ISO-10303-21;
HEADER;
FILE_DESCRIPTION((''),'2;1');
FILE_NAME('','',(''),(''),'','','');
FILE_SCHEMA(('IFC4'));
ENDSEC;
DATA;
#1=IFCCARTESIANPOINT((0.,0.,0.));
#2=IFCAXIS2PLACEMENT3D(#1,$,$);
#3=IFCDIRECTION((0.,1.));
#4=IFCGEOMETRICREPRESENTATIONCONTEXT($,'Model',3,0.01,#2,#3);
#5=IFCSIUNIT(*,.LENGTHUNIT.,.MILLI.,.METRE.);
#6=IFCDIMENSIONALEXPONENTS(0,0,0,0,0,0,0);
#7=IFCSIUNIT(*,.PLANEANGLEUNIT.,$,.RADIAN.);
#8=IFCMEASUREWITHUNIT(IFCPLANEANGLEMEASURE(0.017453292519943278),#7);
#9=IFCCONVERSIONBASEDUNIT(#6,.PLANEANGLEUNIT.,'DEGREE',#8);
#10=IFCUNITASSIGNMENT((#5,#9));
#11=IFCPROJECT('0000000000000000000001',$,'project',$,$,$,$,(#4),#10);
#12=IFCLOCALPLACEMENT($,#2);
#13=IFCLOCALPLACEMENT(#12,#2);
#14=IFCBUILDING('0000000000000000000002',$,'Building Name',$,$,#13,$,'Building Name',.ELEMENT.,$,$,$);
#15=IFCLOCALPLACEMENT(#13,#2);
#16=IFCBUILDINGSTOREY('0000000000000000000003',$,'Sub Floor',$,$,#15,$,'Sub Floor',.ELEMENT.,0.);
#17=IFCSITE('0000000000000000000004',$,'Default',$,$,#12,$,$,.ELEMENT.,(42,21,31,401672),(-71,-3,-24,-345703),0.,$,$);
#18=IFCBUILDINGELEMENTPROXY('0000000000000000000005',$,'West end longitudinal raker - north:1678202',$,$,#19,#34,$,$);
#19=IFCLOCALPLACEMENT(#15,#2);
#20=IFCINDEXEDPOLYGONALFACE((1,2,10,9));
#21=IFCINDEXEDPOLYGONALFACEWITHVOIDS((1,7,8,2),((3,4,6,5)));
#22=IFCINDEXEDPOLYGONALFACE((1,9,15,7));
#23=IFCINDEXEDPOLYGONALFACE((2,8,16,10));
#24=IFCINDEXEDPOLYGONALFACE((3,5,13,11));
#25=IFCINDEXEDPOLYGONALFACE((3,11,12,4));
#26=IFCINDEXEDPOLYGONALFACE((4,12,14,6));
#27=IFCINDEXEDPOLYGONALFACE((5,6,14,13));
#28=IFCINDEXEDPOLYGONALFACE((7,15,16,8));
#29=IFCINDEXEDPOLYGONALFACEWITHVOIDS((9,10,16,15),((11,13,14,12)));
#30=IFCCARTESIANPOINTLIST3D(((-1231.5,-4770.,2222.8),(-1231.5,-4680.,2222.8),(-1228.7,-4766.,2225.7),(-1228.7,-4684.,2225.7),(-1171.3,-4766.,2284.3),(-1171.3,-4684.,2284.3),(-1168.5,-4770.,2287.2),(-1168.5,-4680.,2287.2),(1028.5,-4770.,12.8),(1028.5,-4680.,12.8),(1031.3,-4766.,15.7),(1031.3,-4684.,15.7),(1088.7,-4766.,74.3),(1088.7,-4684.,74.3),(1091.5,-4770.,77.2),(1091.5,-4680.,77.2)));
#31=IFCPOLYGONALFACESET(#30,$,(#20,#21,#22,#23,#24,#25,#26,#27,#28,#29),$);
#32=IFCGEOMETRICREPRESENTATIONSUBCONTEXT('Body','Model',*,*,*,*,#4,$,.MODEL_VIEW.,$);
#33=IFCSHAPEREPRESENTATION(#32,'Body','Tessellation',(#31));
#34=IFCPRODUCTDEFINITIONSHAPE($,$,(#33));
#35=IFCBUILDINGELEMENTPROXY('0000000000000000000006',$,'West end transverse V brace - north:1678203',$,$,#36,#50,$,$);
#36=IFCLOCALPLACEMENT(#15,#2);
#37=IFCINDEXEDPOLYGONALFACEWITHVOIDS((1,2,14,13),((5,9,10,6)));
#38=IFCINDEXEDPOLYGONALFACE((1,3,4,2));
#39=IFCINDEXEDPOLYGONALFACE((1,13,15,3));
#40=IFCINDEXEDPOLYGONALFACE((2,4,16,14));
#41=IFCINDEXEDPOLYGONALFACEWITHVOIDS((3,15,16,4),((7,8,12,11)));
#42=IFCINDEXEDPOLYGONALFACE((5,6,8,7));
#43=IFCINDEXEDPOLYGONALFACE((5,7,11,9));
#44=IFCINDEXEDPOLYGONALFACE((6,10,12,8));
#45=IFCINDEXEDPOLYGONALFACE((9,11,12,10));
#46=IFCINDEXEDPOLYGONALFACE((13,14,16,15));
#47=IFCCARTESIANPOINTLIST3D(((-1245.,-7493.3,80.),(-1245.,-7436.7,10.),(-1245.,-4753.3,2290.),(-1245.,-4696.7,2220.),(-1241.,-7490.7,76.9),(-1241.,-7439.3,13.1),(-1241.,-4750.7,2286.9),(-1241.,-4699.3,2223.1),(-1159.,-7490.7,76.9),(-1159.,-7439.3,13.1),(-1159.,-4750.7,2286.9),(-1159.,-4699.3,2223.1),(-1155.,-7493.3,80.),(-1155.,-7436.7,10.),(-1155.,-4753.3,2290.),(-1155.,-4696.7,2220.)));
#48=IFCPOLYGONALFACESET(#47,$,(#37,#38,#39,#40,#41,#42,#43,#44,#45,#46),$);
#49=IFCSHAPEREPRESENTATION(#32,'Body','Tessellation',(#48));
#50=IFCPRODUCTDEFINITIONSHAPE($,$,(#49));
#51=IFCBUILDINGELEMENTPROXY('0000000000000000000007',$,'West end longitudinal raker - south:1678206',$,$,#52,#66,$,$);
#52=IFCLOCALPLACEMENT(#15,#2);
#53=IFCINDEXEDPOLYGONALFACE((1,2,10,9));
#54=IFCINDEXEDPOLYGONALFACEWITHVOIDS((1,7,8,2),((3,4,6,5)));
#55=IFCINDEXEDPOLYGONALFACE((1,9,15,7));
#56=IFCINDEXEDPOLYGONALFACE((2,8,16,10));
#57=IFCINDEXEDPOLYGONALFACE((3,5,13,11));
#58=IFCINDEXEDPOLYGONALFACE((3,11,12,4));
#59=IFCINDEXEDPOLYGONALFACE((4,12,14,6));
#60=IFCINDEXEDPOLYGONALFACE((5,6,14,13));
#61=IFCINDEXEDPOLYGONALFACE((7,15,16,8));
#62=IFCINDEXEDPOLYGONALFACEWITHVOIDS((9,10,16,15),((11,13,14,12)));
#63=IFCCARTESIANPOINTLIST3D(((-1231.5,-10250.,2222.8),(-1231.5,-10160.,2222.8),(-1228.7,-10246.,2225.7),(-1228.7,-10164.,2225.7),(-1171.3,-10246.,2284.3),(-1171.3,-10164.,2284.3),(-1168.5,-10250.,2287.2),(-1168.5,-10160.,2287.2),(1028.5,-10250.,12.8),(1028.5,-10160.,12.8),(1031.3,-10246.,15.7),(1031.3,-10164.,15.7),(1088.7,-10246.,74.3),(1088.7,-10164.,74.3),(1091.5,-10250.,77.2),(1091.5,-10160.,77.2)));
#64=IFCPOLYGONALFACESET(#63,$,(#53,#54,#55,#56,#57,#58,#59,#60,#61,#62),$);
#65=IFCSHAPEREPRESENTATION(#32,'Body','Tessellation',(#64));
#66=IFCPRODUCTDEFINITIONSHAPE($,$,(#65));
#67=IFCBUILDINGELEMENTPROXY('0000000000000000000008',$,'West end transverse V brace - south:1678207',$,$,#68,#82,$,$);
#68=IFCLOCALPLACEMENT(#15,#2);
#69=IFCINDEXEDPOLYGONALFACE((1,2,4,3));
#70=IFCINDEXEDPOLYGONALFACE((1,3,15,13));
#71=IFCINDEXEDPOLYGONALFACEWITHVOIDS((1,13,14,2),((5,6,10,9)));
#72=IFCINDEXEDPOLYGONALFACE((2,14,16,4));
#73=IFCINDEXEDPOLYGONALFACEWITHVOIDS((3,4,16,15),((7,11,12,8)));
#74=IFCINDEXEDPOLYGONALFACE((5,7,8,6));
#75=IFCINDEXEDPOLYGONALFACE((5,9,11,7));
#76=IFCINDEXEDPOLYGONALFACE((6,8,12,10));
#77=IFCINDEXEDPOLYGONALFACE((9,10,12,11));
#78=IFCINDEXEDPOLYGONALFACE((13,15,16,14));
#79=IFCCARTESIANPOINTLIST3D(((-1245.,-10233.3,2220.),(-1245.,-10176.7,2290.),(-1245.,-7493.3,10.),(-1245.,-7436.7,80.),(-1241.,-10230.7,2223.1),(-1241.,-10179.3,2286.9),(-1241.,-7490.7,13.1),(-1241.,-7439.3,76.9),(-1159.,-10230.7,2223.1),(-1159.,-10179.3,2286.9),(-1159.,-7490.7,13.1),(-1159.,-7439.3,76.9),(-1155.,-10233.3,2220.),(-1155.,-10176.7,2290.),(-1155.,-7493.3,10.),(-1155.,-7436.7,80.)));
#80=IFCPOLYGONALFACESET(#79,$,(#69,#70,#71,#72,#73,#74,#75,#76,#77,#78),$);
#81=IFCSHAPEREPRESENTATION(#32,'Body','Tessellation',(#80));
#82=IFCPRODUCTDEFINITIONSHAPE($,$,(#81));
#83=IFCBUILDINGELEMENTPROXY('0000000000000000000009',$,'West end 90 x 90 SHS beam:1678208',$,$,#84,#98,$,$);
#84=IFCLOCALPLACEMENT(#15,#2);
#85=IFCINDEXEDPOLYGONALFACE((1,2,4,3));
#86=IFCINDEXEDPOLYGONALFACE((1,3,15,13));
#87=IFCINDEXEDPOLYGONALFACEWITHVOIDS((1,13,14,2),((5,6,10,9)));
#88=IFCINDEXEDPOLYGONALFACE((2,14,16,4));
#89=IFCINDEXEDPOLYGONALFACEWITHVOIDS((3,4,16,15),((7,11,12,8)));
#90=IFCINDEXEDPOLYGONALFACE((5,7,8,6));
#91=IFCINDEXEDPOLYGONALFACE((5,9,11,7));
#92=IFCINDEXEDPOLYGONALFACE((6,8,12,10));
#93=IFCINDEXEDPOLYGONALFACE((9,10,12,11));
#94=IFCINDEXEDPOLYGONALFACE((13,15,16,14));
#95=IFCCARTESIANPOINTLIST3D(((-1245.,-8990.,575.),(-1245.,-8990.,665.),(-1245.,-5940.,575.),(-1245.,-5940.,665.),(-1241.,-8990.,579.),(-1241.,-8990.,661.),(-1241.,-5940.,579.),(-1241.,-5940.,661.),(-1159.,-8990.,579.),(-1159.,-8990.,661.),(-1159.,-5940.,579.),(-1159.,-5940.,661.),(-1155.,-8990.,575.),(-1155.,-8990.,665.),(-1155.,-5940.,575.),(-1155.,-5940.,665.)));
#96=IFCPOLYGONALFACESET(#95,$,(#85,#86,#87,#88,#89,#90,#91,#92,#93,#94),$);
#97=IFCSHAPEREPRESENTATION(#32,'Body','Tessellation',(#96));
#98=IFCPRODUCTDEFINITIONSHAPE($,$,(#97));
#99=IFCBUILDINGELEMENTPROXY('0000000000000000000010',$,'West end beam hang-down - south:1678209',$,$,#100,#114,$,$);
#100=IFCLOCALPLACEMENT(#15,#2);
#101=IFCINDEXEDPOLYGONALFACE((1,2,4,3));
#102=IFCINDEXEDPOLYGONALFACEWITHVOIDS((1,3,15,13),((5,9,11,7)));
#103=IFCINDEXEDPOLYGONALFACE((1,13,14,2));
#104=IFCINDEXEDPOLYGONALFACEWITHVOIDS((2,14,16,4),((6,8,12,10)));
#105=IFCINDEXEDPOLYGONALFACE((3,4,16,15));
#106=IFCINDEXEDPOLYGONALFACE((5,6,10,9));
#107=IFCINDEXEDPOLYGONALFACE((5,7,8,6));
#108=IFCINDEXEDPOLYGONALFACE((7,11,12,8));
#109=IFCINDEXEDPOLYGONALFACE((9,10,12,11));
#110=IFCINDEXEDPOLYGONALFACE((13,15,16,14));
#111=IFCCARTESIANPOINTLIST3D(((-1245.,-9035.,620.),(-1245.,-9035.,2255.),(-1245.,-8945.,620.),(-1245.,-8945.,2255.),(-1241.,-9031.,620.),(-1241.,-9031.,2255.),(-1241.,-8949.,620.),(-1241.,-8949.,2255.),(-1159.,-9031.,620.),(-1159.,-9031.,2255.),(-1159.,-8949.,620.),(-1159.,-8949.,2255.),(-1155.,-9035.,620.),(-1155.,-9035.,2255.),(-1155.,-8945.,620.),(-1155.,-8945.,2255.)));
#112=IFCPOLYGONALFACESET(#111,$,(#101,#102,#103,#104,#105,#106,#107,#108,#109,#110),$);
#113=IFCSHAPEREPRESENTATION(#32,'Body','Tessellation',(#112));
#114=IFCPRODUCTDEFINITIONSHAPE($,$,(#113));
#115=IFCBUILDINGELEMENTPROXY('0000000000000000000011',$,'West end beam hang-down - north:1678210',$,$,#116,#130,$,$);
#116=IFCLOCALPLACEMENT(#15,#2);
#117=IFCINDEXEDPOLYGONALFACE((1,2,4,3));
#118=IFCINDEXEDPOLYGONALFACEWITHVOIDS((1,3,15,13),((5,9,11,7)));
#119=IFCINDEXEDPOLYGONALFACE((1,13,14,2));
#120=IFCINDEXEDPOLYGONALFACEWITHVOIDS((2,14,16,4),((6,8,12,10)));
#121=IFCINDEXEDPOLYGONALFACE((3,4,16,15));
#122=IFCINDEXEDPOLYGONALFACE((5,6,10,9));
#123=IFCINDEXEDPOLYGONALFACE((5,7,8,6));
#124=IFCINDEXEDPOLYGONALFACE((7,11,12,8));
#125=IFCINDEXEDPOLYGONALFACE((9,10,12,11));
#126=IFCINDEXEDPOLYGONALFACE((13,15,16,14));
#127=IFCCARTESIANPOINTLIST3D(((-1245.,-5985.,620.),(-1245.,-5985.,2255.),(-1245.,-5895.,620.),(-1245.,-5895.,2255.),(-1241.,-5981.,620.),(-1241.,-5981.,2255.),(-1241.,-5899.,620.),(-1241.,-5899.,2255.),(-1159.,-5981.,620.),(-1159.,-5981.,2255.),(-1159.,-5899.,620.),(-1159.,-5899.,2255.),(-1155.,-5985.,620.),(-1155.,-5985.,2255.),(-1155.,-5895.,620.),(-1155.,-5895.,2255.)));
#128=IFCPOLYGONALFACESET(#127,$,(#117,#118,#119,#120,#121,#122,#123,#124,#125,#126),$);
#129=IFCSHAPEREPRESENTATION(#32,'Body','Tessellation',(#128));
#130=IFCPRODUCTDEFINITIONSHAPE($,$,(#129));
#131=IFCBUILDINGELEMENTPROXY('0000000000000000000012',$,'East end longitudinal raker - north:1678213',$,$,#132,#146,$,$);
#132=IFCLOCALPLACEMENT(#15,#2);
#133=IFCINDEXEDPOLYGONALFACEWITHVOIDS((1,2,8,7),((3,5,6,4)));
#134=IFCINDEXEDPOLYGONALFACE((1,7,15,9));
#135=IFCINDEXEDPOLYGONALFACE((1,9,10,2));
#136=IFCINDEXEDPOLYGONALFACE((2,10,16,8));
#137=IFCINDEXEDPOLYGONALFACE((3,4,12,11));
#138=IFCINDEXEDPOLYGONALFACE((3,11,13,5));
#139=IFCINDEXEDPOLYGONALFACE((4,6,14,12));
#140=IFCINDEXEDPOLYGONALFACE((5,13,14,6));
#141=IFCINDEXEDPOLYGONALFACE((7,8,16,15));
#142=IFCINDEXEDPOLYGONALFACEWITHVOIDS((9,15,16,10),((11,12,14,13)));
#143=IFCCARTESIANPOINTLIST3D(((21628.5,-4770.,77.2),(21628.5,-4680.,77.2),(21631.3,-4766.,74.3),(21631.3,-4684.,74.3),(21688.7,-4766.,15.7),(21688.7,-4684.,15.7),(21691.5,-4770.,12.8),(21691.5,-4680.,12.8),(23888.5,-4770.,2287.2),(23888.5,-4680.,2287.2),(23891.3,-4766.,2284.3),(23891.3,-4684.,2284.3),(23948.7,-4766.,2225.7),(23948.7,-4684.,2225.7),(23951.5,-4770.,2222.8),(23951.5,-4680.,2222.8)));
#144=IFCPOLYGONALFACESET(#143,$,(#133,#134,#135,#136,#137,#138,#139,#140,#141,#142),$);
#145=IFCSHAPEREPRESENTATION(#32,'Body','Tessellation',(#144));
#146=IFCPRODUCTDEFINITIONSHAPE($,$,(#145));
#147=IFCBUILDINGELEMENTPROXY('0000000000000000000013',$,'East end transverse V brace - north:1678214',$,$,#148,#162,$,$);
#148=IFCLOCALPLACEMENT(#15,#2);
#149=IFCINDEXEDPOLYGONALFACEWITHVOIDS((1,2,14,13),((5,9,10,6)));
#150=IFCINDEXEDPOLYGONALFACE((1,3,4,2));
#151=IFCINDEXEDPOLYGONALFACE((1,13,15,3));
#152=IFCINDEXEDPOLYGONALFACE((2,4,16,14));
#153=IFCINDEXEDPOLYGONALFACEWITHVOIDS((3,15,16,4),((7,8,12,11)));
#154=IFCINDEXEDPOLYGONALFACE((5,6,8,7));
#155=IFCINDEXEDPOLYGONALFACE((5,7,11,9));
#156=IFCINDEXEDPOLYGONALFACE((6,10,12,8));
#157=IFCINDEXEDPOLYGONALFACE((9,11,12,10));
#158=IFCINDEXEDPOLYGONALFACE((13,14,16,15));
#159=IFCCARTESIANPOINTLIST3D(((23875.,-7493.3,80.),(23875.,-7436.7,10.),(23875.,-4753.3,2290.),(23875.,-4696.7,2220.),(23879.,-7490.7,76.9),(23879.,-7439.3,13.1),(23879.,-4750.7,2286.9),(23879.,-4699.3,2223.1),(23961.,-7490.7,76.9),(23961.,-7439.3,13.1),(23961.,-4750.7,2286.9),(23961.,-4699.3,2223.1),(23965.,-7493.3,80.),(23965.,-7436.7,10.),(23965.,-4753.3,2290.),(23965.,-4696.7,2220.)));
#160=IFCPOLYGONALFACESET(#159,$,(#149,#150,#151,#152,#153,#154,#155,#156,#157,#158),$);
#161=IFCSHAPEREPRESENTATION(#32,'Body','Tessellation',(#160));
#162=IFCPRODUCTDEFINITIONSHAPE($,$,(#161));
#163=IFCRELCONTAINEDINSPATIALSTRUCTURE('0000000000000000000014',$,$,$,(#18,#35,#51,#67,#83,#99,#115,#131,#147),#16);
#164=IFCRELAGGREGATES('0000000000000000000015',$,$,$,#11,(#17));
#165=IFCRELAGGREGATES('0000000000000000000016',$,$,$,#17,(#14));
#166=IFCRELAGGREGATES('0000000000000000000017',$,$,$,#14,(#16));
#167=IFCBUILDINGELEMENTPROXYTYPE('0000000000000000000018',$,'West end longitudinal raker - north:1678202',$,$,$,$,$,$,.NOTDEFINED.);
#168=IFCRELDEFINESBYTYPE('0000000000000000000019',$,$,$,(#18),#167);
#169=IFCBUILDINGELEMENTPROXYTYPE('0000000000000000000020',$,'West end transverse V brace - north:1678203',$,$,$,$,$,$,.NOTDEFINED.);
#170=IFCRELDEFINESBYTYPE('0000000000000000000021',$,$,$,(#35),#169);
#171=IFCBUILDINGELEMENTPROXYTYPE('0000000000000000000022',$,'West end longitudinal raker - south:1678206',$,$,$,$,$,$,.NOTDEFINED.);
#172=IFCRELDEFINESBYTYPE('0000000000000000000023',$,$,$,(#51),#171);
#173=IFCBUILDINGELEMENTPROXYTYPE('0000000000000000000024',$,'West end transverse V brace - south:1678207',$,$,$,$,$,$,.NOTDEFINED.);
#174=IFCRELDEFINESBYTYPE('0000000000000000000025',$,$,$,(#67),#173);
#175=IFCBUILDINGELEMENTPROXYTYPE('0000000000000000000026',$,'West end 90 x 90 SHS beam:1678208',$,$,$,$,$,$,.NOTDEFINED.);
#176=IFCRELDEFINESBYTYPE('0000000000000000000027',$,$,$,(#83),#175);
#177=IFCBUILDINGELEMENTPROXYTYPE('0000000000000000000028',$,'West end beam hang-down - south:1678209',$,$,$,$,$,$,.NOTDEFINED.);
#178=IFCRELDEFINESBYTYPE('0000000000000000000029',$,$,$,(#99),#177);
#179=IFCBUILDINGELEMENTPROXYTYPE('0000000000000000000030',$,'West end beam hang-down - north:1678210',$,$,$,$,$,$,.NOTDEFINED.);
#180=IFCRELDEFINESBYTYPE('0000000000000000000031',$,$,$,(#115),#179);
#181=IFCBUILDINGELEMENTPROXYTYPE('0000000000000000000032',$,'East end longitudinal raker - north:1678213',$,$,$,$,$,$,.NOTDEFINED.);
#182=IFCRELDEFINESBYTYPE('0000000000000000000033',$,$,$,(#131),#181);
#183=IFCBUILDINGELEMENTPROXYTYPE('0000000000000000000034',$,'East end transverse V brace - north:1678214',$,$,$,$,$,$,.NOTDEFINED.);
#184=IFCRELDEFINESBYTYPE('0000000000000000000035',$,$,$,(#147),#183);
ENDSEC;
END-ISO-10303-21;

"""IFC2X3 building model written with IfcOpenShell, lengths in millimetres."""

from ifc_helpers import new_model, entity, si_unit, converted_unit, direction, frame, origin, place, context, subcontext, project, spatial, polyline, outline, extrude, type_object, element, save


model = new_model("IFC2X3")

# Units and contexts
model_context = context("Model", 3, precision=0.01, world=origin(), true_north=direction((0.0, 1.0)))
body_context = subcontext(model_context, "Body", "Model", "MODEL_VIEW")
ifc_project = project(units=[si_unit("LENGTHUNIT", "METRE", prefix="MILLI"), converted_unit("PLANEANGLEUNIT", "DEGREE", entity("IfcPlaneAngleMeasure", 0.017453292519943278), si_unit("PLANEANGLEUNIT", "RADIAN"), dimensions=[0, 0, 0, 0, 0, 0, 0])], contexts=[model_context])

# Site, building, storey
site_placement = place(None, origin())
site = spatial("IfcSite", under=ifc_project, at=site_placement, Name="Default", CompositionType="ELEMENT", RefLatitude=(42, 21, 31, 401672), RefLongitude=(-71, -3, -24, -345703), RefElevation=0.0)
building_placement = place(site_placement, origin())
building = spatial("IfcBuilding", under=site, at=building_placement, Name="Building Name", LongName="Building Name", CompositionType="ELEMENT")
storey_placement = place(building_placement, origin())
storey = spatial("IfcBuildingStorey", under=building, at=storey_placement, Name="Sub Floor", LongName="Sub Floor", CompositionType="ELEMENT", Elevation=0.0)

# Building element proxies
building_element_proxy_type_1 = type_object("IfcBuildingElementProxyType", Name="West end longitudinal raker - north:1678202", PredefinedType="NOTDEFINED")
proxy_1_placement = place(storey_placement, origin())
element("IfcBuildingElementProxy", 1, at=proxy_1_placement, inside=storey, type_object=building_element_proxy_type_1, Name="West end longitudinal raker - north:1678202", context=body_context, shape_type="SweptSolid", body=[
    extrude(outline(polyline([(-45.0, -45.0), (45.0, -45.0), (45.0, 45.0), (-45.0, 45.0), (-45.0, -45.0)]), holes=[polyline([(-41.0, -41.0), (-41.0, 41.0), (41.0, 41.0), (41.0, -41.0), (-41.0, -41.0)])]), frame((-1200.0, -4725.0, 2255.0), z_axis=(0.714972, 0.0, -0.699154), x_axis=(-0.699154, 0.0, -0.714972)), (0.0, 0.0, 1.0), 3161.0),
])
building_element_proxy_type_2 = type_object("IfcBuildingElementProxyType", Name="West end transverse V brace - north:1678203", PredefinedType="NOTDEFINED")
proxy_2_placement = place(storey_placement, origin())
element("IfcBuildingElementProxy", 2, at=proxy_2_placement, inside=storey, type_object=building_element_proxy_type_2, Name="West end transverse V brace - north:1678203", context=body_context, shape_type="SweptSolid", body=[
    extrude(outline(polyline([(-45.0, -45.0), (45.0, -45.0), (45.0, 45.0), (-45.0, 45.0), (-45.0, -45.0)]), holes=[polyline([(-41.0, -41.0), (-41.0, 41.0), (41.0, 41.0), (41.0, -41.0), (-41.0, -41.0)])]), frame((-1200.0, -7465.0, 45.0), z_axis=(0.0, 0.778368, 0.627808), x_axis=(1.0, 0.0, 0.0)), (0.0, 0.0, 1.0), 3520.2),
])
building_element_proxy_type_3 = type_object("IfcBuildingElementProxyType", Name="West end longitudinal raker - south:1678206", PredefinedType="NOTDEFINED")
proxy_3_placement = place(storey_placement, origin())
element("IfcBuildingElementProxy", 3, at=proxy_3_placement, inside=storey, type_object=building_element_proxy_type_3, Name="West end longitudinal raker - south:1678206", context=body_context, shape_type="SweptSolid", body=[
    extrude(outline(polyline([(-45.0, -45.0), (45.0, -45.0), (45.0, 45.0), (-45.0, 45.0), (-45.0, -45.0)]), holes=[polyline([(-41.0, -41.0), (-41.0, 41.0), (41.0, 41.0), (41.0, -41.0), (-41.0, -41.0)])]), frame((-1200.0, -10205.0, 2255.0), z_axis=(0.714972, 0.0, -0.699154), x_axis=(-0.699154, 0.0, -0.714972)), (0.0, 0.0, 1.0), 3161.0),
])
building_element_proxy_type_4 = type_object("IfcBuildingElementProxyType", Name="West end transverse V brace - south:1678207", PredefinedType="NOTDEFINED")
proxy_4_placement = place(storey_placement, origin())
element("IfcBuildingElementProxy", 4, at=proxy_4_placement, inside=storey, type_object=building_element_proxy_type_4, Name="West end transverse V brace - south:1678207", context=body_context, shape_type="SweptSolid", body=[
    extrude(outline(polyline([(-45.0, -45.0), (45.0, -45.0), (45.0, 45.0), (-45.0, 45.0), (-45.0, -45.0)]), holes=[polyline([(-41.0, -41.0), (-41.0, 41.0), (41.0, 41.0), (41.0, -41.0), (-41.0, -41.0)])]), frame((-1200.0, -10205.0, 2255.0), z_axis=(0.0, 0.778368, -0.627808), x_axis=(0.0, -0.627808, -0.778368)), (0.0, 0.0, 1.0), 3520.2),
])
building_element_proxy_type_5 = type_object("IfcBuildingElementProxyType", Name="West end 90 x 90 SHS beam:1678208", PredefinedType="NOTDEFINED")
proxy_5_placement = place(storey_placement, origin())
element("IfcBuildingElementProxy", 5, at=proxy_5_placement, inside=storey, type_object=building_element_proxy_type_5, Name="West end 90 x 90 SHS beam:1678208", context=body_context, shape_type="SweptSolid", body=[
    extrude(outline(polyline([(-45.0, -45.0), (45.0, -45.0), (45.0, 45.0), (-45.0, 45.0), (-45.0, -45.0)]), holes=[polyline([(-41.0, -41.0), (-41.0, 41.0), (41.0, 41.0), (41.0, -41.0), (-41.0, -41.0)])]), frame((-1200.0, -8990.0, 620.0), z_axis=(0.0, 1.0, 0.0), x_axis=(1.0, 0.0, 0.0)), (0.0, 0.0, 1.0), 3050.0),
])
building_element_proxy_type_6 = type_object("IfcBuildingElementProxyType", Name="West end beam hang-down - south:1678209", PredefinedType="NOTDEFINED")
proxy_6_placement = place(storey_placement, origin())
element("IfcBuildingElementProxy", 6, at=proxy_6_placement, inside=storey, type_object=building_element_proxy_type_6, Name="West end beam hang-down - south:1678209", context=body_context, shape_type="SweptSolid", body=[
    extrude(outline(polyline([(-45.0, -45.0), (45.0, -45.0), (45.0, 45.0), (-45.0, 45.0), (-45.0, -45.0)]), holes=[polyline([(-41.0, -41.0), (-41.0, 41.0), (41.0, 41.0), (41.0, -41.0), (-41.0, -41.0)])]), frame((-1200.0, -8990.0, 620.0), z_axis=(0.0, 0.0, 1.0), x_axis=(0.0, 1.0, 0.0)), (0.0, 0.0, 1.0), 1635.0),
])
building_element_proxy_type_7 = type_object("IfcBuildingElementProxyType", Name="West end beam hang-down - north:1678210", PredefinedType="NOTDEFINED")
proxy_7_placement = place(storey_placement, origin())
element("IfcBuildingElementProxy", 7, at=proxy_7_placement, inside=storey, type_object=building_element_proxy_type_7, Name="West end beam hang-down - north:1678210", context=body_context, shape_type="SweptSolid", body=[
    extrude(outline(polyline([(-45.0, -45.0), (45.0, -45.0), (45.0, 45.0), (-45.0, 45.0), (-45.0, -45.0)]), holes=[polyline([(-41.0, -41.0), (-41.0, 41.0), (41.0, 41.0), (41.0, -41.0), (-41.0, -41.0)])]), frame((-1200.0, -5940.0, 620.0), z_axis=(0.0, 0.0, 1.0), x_axis=(0.0, 1.0, 0.0)), (0.0, 0.0, 1.0), 1635.0),
])
building_element_proxy_type_8 = type_object("IfcBuildingElementProxyType", Name="East end longitudinal raker - north:1678213", PredefinedType="NOTDEFINED")
proxy_8_placement = place(storey_placement, origin())
element("IfcBuildingElementProxy", 8, at=proxy_8_placement, inside=storey, type_object=building_element_proxy_type_8, Name="East end longitudinal raker - north:1678213", context=body_context, shape_type="SweptSolid", body=[
    extrude(outline(polyline([(-45.0, -45.0), (45.0, -45.0), (45.0, 45.0), (-45.0, 45.0), (-45.0, -45.0)]), holes=[polyline([(-41.0, -41.0), (-41.0, 41.0), (41.0, 41.0), (41.0, -41.0), (-41.0, -41.0)])]), frame((21660.0, -4725.0, 45.0), z_axis=(0.714972, 0.0, 0.699154), x_axis=(0.0, -1.0, 0.0)), (0.0, 0.0, 1.0), 3161.0),
])
building_element_proxy_type_9 = type_object("IfcBuildingElementProxyType", Name="East end transverse V brace - north:1678214", PredefinedType="NOTDEFINED")
proxy_9_placement = place(storey_placement, origin())
element("IfcBuildingElementProxy", 9, at=proxy_9_placement, inside=storey, type_object=building_element_proxy_type_9, Name="East end transverse V brace - north:1678214", context=body_context, shape_type="SweptSolid", body=[
    extrude(outline(polyline([(-45.0, -45.0), (45.0, -45.0), (45.0, 45.0), (-45.0, 45.0), (-45.0, -45.0)]), holes=[polyline([(-41.0, -41.0), (-41.0, 41.0), (41.0, 41.0), (41.0, -41.0), (-41.0, -41.0)])]), frame((23920.0, -7465.0, 45.0), z_axis=(0.0, 0.778368, 0.627808), x_axis=(1.0, 0.0, 0.0)), (0.0, 0.0, 1.0), 3520.2),
])

save(model, "model.ifc")
